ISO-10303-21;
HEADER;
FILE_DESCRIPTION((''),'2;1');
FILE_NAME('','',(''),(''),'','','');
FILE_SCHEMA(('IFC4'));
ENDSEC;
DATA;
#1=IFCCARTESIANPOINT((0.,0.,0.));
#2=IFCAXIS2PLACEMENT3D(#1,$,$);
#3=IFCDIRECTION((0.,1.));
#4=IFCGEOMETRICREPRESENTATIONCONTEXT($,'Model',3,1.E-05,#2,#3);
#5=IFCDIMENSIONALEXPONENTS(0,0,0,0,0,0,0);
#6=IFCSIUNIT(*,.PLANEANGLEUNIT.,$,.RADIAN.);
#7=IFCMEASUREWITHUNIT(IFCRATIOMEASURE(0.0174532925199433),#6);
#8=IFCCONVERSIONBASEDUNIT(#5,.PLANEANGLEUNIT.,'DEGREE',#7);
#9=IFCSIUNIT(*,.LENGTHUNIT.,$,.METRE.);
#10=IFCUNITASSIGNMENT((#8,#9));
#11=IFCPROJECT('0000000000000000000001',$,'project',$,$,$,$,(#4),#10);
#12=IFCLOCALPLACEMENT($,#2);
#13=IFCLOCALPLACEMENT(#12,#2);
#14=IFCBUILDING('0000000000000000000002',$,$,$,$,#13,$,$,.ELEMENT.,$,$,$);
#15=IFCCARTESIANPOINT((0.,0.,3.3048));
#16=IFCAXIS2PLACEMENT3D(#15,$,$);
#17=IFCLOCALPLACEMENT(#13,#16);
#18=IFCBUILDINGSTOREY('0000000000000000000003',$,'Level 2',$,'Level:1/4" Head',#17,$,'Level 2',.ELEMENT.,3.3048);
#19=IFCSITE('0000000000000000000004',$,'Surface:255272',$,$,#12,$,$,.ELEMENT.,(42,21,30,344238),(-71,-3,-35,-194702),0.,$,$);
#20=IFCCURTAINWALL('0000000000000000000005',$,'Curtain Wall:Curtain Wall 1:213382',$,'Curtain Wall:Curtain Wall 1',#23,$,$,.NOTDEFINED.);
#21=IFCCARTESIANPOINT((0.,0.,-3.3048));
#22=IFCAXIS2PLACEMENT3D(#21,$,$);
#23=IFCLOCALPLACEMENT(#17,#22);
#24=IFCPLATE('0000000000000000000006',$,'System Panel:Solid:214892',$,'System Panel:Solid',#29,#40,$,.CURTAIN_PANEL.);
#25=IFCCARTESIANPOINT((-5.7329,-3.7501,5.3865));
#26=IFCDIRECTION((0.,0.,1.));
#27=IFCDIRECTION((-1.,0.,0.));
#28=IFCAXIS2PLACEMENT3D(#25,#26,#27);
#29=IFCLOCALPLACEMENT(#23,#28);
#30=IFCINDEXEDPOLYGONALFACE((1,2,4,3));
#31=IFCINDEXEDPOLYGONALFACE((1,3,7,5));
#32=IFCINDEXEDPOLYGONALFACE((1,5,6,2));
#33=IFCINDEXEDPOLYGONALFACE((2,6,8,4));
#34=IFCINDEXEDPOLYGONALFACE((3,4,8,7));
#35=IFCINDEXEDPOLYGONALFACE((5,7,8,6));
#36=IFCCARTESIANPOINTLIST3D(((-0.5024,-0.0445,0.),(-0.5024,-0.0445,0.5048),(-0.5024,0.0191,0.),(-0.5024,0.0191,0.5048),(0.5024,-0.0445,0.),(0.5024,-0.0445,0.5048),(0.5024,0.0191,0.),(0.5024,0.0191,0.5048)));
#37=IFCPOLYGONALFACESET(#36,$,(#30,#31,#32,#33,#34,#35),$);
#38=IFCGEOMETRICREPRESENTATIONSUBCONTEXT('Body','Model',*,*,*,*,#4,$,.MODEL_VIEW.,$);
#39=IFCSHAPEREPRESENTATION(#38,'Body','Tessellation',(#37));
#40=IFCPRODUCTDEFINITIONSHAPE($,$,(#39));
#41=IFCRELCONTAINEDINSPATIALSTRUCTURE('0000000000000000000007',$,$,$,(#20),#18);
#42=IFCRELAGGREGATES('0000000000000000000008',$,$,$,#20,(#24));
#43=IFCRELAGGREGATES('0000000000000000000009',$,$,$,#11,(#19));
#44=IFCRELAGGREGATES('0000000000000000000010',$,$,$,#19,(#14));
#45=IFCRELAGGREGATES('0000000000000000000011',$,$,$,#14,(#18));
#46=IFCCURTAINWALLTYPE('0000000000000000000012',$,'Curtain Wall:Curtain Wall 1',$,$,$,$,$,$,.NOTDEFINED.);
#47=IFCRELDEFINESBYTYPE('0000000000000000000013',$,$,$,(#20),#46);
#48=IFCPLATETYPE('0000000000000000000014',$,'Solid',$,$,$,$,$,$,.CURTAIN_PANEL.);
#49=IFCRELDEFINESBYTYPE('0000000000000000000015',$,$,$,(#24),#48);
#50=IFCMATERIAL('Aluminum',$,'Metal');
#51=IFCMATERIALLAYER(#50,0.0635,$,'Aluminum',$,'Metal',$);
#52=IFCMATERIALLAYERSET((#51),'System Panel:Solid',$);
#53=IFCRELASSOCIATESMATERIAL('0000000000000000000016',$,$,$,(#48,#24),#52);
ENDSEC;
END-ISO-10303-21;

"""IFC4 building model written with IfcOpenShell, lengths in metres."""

from ifc_helpers import new_model, entity, si_unit, converted_unit, direction, frame, origin, origin_2d_with_axis, place, context, subcontext, project, spatial, rectangle, extrude, shape, source, transform, mapped, material, layer, layer_set, layer_usage, type_object, type_shapes, element, aggregate, save


model = new_model("IFC4")

# Units and contexts
model_context = context("Model", 3, precision=1e-05, world=origin(), true_north=direction((0.0, 1.0)))
body_context = subcontext(model_context, "Body", "Model", "MODEL_VIEW")
footprint_context = subcontext(model_context, "FootPrint", "Model", "MODEL_VIEW")
ifc_project = project(units=[converted_unit("PLANEANGLEUNIT", "DEGREE", entity("IfcRatioMeasure", 0.0174532925199433), si_unit("PLANEANGLEUNIT", "RADIAN"), dimensions=[0, 0, 0, 0, 0, 0, 0]), si_unit("LENGTHUNIT", "METRE")], contexts=[model_context])

# Site, building, storey
site_placement = place(None, origin())
site = spatial("IfcSite", under=ifc_project, at=site_placement, Name="Surface:255272", CompositionType="ELEMENT", RefLatitude=(42, 21, 30, 344238), RefLongitude=(-71, -3, -35, -194702), RefElevation=0.0)
building_placement = place(site_placement, origin())
building = spatial("IfcBuilding", under=site, at=building_placement, CompositionType="ELEMENT")
storey_placement = place(building_placement, frame((0.0, 0.0, 3.3048)))
storey = spatial("IfcBuildingStorey", under=building, at=storey_placement, Name="Level 2", ObjectType="Level:1/4\" Head", LongName="Level 2", CompositionType="ELEMENT", Elevation=3.3048)

# Curtain wall, plate
curtain_wall_type = type_object("IfcCurtainWallType", Name="Curtain Wall:Curtain Wall 1", PredefinedType="NOTDEFINED")
curtain_wall_placement = place(storey_placement, frame((0.0, 0.0, -3.3048)))
curtain_wall = element("IfcCurtainWall", 1, at=curtain_wall_placement, inside=storey, type_object=curtain_wall_type, Name="Curtain Wall:Curtain Wall 1:213382", ObjectType="Curtain Wall:Curtain Wall 1", PredefinedType="NOTDEFINED")
ifc_material_1 = material(Name="Aluminum", Category="Metal")
ifc_layer_1 = layer(ifc_material_1, 0.0635, Name="Aluminum", Category="Metal")
ifc_layer_set_1 = layer_set([ifc_layer_1], Name="System Panel:Solid")
ifc_layer_usage_1 = layer_usage(ifc_layer_set_1, "AXIS3", "POSITIVE", 0.0417)
plate_type = type_object("IfcPlateType", Name="Solid", PredefinedType="CURTAIN_PANEL", material=ifc_layer_set_1)
shared_shape_1 = source(origin(), body_context, "Body", "SweptSolid", [
    extrude(rectangle(XDim=0.0635, YDim=1.0048, at=origin_2d_with_axis()), frame((0.0, -0.0127, 0.0), z_axis=(0.0, 0.0, 1.0), x_axis=(0.0, 1.0, 0.0)), (0.0, 0.0, 1.0), 0.5048),
])
cartesian_point = entity("IfcCartesianPoint", [0.5024, -0.0445])
shared_shape_2 = source(origin(), footprint_context, "FootPrint", "Curve2D", [
    entity("IfcPolyline", [cartesian_point, entity("IfcCartesianPoint", [0.5024, 0.0191]), entity("IfcCartesianPoint", [-0.5024, 0.0191]), entity("IfcCartesianPoint", [-0.5024, -0.0445]), cartesian_point]),
])
type_shapes(plate_type, [shared_shape_1, shared_shape_2])
plate_placement = place(curtain_wall_placement, frame((-5.7329, -3.7501, 5.3865), z_axis=(0.0, 0.0, 1.0), x_axis=(-1.0, 0.0, 0.0)))
plate = element("IfcPlate", 2, at=plate_placement, type_object=plate_type, material=ifc_layer_usage_1, Name="System Panel:Solid:214892", ObjectType="System Panel:Solid", PredefinedType="CURTAIN_PANEL", shapes=[
    shape(body_context, "Body", "MappedRepresentation", [mapped(shared_shape_1, transform((0.0, 0.0, 0.0), scale=1.0))]),
    shape(body_context, "Body", "MappedRepresentation", [mapped(shared_shape_2, transform((0.0, 0.0, 0.0), scale=1.0))]),
])
aggregate(curtain_wall, [plate])

save(model, "model.ifc")
